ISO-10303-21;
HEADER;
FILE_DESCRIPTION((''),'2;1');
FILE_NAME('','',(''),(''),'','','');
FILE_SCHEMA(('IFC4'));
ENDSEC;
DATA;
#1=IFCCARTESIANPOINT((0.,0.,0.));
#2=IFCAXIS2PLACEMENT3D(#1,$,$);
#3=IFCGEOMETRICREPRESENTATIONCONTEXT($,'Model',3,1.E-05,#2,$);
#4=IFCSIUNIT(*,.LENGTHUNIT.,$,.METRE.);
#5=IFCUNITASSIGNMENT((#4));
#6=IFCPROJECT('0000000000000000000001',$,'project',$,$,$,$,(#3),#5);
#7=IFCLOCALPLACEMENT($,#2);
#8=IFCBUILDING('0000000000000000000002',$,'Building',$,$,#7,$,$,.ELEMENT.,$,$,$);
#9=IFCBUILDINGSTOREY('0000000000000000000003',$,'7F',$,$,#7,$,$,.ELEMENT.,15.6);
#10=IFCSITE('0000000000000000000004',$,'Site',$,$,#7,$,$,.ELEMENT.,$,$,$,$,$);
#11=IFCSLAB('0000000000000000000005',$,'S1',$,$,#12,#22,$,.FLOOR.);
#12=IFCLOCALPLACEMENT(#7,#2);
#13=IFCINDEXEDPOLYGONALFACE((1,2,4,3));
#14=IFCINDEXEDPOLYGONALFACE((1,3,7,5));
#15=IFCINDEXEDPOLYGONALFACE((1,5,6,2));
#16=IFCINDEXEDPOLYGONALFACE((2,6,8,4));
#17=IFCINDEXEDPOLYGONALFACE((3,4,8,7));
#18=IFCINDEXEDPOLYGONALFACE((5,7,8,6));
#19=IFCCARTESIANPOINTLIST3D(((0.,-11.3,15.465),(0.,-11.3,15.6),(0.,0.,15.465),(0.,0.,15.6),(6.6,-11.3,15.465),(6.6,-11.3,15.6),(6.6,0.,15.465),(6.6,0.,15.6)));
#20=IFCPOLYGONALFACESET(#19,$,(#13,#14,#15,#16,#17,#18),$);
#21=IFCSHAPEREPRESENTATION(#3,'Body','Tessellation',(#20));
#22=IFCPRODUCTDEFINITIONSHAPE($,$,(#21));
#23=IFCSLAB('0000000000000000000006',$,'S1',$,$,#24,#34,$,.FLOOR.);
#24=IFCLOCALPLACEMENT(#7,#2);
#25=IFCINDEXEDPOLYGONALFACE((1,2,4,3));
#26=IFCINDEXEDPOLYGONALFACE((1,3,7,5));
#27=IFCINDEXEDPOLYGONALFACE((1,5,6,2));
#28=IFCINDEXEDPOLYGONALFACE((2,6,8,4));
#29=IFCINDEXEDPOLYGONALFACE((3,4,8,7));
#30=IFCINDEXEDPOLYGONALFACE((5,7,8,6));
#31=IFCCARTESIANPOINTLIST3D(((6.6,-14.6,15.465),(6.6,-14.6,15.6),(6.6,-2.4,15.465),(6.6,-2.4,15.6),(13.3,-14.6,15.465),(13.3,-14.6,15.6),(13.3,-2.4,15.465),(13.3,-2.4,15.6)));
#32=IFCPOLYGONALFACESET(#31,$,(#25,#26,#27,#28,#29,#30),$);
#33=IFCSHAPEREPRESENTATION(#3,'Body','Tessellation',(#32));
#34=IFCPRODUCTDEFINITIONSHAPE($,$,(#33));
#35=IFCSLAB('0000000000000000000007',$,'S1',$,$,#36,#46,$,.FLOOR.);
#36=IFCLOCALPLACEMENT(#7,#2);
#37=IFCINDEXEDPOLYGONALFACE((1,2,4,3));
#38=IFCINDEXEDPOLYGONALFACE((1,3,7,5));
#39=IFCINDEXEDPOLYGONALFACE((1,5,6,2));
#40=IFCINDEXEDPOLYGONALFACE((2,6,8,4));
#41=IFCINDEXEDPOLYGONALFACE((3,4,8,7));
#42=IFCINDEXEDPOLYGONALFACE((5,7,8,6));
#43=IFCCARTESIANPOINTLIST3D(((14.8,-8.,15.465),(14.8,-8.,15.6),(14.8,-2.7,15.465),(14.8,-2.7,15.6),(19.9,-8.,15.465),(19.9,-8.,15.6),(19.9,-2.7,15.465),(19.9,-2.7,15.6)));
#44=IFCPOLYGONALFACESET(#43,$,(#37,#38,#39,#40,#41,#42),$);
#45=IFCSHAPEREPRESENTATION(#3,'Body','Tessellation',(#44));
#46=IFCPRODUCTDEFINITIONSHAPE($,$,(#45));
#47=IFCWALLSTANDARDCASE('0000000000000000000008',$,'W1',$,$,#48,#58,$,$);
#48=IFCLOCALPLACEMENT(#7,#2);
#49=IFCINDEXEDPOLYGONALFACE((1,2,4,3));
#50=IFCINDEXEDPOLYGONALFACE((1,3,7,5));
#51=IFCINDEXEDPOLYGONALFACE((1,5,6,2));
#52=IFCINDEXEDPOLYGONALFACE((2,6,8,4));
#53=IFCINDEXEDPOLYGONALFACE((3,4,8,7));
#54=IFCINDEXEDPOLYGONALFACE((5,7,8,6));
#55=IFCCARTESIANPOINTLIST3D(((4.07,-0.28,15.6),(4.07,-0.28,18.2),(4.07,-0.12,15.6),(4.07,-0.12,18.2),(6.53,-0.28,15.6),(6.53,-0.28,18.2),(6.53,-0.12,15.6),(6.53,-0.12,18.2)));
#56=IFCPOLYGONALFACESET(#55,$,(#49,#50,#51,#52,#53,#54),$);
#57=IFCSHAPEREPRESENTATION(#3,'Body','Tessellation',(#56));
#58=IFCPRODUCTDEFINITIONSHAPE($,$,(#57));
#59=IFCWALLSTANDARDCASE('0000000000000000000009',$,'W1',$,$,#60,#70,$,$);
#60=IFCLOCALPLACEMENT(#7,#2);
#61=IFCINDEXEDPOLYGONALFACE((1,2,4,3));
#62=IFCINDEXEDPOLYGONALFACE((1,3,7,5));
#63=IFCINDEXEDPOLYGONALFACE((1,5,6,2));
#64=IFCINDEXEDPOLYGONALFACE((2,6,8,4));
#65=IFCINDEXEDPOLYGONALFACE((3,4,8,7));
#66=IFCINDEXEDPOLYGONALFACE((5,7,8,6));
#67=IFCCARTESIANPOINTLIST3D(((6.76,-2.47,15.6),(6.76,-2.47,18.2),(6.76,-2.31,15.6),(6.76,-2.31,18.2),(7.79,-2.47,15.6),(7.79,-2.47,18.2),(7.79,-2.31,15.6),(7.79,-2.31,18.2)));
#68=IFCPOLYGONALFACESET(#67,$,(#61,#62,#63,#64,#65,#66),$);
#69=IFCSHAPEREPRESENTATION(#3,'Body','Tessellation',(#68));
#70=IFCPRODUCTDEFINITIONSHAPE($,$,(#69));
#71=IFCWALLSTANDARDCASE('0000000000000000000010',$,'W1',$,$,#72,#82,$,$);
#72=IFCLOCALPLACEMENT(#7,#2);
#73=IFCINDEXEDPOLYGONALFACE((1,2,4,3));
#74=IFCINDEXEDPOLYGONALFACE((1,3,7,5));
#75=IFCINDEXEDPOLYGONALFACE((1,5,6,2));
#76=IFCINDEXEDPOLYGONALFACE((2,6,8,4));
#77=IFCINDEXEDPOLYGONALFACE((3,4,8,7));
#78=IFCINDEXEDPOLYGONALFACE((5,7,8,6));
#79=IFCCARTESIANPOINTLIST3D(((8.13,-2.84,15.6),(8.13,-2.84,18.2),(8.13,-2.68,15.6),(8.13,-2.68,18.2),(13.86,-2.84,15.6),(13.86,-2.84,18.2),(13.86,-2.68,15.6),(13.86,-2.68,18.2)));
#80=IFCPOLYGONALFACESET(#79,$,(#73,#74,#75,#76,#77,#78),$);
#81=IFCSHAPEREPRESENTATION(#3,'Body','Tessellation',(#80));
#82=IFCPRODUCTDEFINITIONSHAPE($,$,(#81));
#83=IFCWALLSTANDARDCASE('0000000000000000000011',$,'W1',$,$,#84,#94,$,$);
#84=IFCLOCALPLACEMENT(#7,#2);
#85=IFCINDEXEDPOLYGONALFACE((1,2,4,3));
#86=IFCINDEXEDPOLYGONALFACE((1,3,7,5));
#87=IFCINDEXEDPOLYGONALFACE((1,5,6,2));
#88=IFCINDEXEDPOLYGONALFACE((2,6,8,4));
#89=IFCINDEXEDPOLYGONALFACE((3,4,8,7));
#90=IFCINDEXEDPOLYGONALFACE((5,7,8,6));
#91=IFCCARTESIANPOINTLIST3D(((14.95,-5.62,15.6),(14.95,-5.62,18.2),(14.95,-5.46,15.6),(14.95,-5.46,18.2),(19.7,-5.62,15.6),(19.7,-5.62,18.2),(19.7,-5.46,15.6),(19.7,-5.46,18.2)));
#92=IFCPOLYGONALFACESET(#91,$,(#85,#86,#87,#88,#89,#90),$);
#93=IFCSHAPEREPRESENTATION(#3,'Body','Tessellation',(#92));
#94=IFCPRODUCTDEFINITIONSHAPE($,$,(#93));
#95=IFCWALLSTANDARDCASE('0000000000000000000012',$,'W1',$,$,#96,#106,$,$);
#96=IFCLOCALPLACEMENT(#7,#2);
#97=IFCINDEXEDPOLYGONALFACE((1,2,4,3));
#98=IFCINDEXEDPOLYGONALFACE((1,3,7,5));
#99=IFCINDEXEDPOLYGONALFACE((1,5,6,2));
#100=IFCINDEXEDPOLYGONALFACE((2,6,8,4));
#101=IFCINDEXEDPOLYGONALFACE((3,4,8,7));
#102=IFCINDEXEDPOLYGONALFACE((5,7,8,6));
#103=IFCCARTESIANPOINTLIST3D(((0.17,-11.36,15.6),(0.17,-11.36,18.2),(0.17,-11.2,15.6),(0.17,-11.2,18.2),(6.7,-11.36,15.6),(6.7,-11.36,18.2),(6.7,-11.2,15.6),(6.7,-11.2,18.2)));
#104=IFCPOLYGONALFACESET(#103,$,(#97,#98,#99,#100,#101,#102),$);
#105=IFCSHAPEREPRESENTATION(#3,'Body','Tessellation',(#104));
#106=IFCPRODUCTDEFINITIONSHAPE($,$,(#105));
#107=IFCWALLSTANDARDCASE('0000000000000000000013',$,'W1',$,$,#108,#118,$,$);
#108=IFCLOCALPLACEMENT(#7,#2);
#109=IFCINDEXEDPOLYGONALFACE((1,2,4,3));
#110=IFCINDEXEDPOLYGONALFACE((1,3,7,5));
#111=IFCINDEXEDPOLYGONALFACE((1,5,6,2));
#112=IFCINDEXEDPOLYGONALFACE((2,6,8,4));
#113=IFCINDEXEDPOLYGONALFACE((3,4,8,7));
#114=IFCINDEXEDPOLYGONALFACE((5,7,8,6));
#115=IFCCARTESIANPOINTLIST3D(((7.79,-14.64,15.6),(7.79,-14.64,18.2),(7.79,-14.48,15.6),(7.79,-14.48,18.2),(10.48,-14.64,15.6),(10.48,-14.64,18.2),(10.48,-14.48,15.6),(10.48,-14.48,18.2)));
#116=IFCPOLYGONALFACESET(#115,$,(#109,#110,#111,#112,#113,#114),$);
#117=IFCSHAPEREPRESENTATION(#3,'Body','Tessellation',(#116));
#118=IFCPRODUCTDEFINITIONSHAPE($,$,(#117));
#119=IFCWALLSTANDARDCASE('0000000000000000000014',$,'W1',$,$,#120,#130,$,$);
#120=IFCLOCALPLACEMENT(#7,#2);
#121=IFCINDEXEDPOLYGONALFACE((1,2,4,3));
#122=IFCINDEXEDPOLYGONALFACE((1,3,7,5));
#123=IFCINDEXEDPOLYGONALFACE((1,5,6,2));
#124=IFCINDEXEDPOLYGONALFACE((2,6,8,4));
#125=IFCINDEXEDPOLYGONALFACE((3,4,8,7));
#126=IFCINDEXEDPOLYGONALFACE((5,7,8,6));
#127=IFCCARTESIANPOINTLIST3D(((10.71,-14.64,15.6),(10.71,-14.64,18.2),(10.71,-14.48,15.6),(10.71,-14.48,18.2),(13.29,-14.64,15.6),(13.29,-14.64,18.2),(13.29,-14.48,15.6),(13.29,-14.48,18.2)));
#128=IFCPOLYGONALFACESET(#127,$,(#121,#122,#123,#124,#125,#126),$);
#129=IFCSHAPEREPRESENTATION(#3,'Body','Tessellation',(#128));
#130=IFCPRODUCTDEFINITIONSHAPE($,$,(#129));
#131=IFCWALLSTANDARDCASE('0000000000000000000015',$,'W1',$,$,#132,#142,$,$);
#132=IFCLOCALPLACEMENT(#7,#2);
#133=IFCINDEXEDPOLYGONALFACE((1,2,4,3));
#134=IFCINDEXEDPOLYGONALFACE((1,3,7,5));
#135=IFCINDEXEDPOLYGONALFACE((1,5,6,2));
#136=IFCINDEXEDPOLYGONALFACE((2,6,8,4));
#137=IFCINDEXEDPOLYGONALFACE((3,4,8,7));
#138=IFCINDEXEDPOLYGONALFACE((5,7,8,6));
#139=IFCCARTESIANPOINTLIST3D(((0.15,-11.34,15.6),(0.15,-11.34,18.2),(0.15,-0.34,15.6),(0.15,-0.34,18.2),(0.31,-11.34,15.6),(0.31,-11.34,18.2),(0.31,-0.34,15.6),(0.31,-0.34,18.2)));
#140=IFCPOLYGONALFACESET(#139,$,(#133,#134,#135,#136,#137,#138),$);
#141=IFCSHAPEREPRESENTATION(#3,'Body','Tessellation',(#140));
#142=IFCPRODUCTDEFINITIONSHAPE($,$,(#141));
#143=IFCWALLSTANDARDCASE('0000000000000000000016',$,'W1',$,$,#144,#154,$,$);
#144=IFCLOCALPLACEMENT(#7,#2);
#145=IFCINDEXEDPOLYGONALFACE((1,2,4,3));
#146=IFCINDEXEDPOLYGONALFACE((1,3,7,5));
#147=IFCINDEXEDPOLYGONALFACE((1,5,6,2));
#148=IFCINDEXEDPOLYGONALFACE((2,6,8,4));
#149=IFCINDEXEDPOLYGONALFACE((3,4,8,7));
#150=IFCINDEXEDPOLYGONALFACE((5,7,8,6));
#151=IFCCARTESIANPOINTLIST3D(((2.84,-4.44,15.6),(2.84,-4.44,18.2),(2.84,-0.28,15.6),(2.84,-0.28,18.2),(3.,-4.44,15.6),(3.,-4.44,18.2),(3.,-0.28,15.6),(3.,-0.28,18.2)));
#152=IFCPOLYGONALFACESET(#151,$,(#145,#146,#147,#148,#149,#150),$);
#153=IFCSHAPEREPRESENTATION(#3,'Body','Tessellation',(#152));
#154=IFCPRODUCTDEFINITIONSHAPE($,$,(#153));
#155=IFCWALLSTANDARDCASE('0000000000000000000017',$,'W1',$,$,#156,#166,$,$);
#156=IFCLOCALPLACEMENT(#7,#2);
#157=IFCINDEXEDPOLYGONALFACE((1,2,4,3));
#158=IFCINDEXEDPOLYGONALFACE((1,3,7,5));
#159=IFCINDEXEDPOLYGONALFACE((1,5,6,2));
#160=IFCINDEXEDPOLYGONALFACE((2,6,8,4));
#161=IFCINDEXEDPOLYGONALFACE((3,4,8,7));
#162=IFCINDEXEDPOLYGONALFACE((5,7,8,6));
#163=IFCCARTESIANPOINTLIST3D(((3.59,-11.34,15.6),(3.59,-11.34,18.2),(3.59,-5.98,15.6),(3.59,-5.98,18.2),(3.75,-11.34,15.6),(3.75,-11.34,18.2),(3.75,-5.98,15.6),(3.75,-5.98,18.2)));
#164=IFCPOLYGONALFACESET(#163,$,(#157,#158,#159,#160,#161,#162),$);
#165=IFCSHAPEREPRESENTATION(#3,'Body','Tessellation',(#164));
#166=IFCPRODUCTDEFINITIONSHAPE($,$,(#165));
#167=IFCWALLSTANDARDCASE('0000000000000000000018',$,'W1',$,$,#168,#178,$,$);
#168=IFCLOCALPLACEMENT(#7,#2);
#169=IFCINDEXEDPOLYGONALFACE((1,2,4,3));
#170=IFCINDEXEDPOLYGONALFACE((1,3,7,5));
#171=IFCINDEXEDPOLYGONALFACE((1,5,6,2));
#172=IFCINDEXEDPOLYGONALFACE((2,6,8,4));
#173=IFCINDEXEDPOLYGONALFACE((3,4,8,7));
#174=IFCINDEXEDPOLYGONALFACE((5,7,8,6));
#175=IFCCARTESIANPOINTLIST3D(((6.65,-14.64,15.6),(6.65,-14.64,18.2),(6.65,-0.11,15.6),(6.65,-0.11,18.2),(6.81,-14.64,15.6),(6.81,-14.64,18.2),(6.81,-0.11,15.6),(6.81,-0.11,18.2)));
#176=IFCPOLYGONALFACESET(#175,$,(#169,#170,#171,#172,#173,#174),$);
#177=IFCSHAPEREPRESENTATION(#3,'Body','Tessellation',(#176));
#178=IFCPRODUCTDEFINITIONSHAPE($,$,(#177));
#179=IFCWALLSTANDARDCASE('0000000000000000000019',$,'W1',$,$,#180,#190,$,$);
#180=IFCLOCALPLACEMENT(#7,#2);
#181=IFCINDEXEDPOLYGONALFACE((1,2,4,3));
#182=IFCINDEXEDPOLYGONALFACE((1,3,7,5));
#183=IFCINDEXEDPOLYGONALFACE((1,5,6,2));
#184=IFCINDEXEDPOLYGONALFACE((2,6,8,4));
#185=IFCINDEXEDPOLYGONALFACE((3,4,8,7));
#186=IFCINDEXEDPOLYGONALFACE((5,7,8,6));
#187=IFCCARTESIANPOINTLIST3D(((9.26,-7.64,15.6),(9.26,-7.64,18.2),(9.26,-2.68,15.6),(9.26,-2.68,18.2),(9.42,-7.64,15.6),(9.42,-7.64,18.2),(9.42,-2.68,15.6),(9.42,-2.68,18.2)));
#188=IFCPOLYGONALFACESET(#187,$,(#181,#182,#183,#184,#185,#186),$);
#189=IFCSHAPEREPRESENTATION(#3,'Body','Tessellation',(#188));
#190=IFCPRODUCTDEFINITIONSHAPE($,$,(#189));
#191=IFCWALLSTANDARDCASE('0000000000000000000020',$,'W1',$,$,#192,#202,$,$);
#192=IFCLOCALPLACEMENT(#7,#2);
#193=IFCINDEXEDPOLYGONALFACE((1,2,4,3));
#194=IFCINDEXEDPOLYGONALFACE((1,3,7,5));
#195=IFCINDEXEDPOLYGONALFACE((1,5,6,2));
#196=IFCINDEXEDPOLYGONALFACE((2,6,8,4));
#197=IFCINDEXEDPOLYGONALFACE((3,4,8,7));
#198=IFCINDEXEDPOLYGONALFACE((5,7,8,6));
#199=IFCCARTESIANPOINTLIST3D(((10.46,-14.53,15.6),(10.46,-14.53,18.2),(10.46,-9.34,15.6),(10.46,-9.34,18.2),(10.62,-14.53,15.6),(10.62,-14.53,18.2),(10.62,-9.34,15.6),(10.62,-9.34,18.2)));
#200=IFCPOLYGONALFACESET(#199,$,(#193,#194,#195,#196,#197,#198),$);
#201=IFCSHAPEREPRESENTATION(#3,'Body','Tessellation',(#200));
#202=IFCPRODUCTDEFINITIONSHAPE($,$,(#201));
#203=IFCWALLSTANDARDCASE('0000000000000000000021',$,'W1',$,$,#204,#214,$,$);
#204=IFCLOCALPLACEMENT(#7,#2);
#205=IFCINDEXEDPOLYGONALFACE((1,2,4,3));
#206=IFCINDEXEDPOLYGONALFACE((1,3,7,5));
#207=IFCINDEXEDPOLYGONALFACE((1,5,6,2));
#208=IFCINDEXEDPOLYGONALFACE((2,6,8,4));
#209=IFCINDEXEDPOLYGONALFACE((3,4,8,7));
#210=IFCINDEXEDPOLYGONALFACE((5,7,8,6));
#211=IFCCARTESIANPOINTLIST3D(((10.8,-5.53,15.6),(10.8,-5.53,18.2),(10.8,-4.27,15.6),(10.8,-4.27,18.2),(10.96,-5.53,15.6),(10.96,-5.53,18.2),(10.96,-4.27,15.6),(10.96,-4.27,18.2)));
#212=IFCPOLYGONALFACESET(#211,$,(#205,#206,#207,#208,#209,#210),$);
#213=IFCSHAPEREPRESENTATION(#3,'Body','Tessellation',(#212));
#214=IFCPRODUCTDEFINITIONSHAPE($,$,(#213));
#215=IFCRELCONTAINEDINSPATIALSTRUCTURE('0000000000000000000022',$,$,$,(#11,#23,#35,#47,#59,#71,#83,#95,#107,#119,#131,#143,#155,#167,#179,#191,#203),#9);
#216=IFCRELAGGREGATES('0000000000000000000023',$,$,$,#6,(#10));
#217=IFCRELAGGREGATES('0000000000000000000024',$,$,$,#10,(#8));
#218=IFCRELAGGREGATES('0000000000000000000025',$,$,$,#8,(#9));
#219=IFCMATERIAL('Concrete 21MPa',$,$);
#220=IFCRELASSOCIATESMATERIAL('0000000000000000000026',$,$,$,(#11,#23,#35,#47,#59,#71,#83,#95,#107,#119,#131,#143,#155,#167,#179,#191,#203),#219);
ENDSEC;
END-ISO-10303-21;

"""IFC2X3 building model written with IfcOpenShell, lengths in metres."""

from ifc_helpers import new_model, si_unit, frame, origin, origin_2d, place, context, project, spatial, rectangle, extrude, material, element, save


model = new_model("IFC2X3")

# Units and contexts
model_context = context("Model", 3, precision=1e-05, world=origin())
ifc_project = project(units=[si_unit("LENGTHUNIT", "METRE")], contexts=[model_context])

# Site, building, storey
placement = place(None, origin())
site = spatial("IfcSite", under=ifc_project, at=placement, Name="Site", CompositionType="ELEMENT")
building = spatial("IfcBuilding", under=site, at=placement, Name="Building", CompositionType="ELEMENT")
storey = spatial("IfcBuildingStorey", under=building, at=placement, Name="7F", CompositionType="ELEMENT", Elevation=15.6)

# Slabs
ifc_material_1 = material(Name="Concrete 21MPa")
slab_1_placement = place(None, frame((3.3, -5.65, 15.465)))
element("IfcSlab", 1, at=slab_1_placement, inside=storey, material=ifc_material_1, Name="S1", PredefinedType="FLOOR", context=model_context, shape_type="SweptSolid", body=[
    extrude(rectangle(XDim=6.6, YDim=11.3, at=origin_2d()), origin(), (0.0, 0.0, 1.0), 0.135),
])
slab_2_placement = place(None, frame((9.95, -8.5, 15.465)))
element("IfcSlab", 2, at=slab_2_placement, inside=storey, material=ifc_material_1, Name="S1", PredefinedType="FLOOR", context=model_context, shape_type="SweptSolid", body=[
    extrude(rectangle(XDim=6.7, YDim=12.2, at=origin_2d()), origin(), (0.0, 0.0, 1.0), 0.135),
])
slab_3_placement = place(None, frame((17.35, -5.35, 15.465)))
element("IfcSlab", 3, at=slab_3_placement, inside=storey, material=ifc_material_1, Name="S1", PredefinedType="FLOOR", context=model_context, shape_type="SweptSolid", body=[
    extrude(rectangle(XDim=5.1, YDim=5.3, at=origin_2d()), origin(), (0.0, 0.0, 1.0), 0.135),
])

# Walls
wall_1_placement = place(None, frame((5.3, -0.2, 15.6)))
element("IfcWallStandardCase", 4, at=wall_1_placement, inside=storey, material=ifc_material_1, Name="W1", context=model_context, shape_type="SweptSolid", body=[
    extrude(rectangle(XDim=2.46, YDim=0.16, at=origin_2d()), origin(), (0.0, 0.0, 1.0), 2.6),
])
wall_2_placement = place(None, frame((7.275, -2.39, 15.6)))
element("IfcWallStandardCase", 5, at=wall_2_placement, inside=storey, material=ifc_material_1, Name="W1", context=model_context, shape_type="SweptSolid", body=[
    extrude(rectangle(XDim=1.03, YDim=0.16, at=origin_2d()), origin(), (0.0, 0.0, 1.0), 2.6),
])
wall_3_placement = place(None, frame((10.995, -2.76, 15.6)))
element("IfcWallStandardCase", 6, at=wall_3_placement, inside=storey, material=ifc_material_1, Name="W1", context=model_context, shape_type="SweptSolid", body=[
    extrude(rectangle(XDim=5.73, YDim=0.16, at=origin_2d()), origin(), (0.0, 0.0, 1.0), 2.6),
])
wall_4_placement = place(None, frame((17.325, -5.54, 15.6)))
element("IfcWallStandardCase", 7, at=wall_4_placement, inside=storey, material=ifc_material_1, Name="W1", context=model_context, shape_type="SweptSolid", body=[
    extrude(rectangle(XDim=4.75, YDim=0.16, at=origin_2d()), origin(), (0.0, 0.0, 1.0), 2.6),
])
wall_5_placement = place(None, frame((3.435, -11.28, 15.6)))
element("IfcWallStandardCase", 8, at=wall_5_placement, inside=storey, material=ifc_material_1, Name="W1", context=model_context, shape_type="SweptSolid", body=[
    extrude(rectangle(XDim=6.53, YDim=0.16, at=origin_2d()), origin(), (0.0, 0.0, 1.0), 2.6),
])
wall_6_placement = place(None, frame((9.135, -14.56, 15.6)))
element("IfcWallStandardCase", 9, at=wall_6_placement, inside=storey, material=ifc_material_1, Name="W1", context=model_context, shape_type="SweptSolid", body=[
    extrude(rectangle(XDim=2.69, YDim=0.16, at=origin_2d()), origin(), (0.0, 0.0, 1.0), 2.6),
])
wall_7_placement = place(None, frame((12.0, -14.56, 15.6)))
element("IfcWallStandardCase", 10, at=wall_7_placement, inside=storey, material=ifc_material_1, Name="W1", context=model_context, shape_type="SweptSolid", body=[
    extrude(rectangle(XDim=2.58, YDim=0.16, at=origin_2d()), origin(), (0.0, 0.0, 1.0), 2.6),
])
wall_8_placement = place(None, frame((0.23, -5.84, 15.6)))
element("IfcWallStandardCase", 11, at=wall_8_placement, inside=storey, material=ifc_material_1, Name="W1", context=model_context, shape_type="SweptSolid", body=[
    extrude(rectangle(XDim=0.16, YDim=11.0, at=origin_2d()), origin(), (0.0, 0.0, 1.0), 2.6),
])
wall_9_placement = place(None, frame((2.92, -2.36, 15.6)))
element("IfcWallStandardCase", 12, at=wall_9_placement, inside=storey, material=ifc_material_1, Name="W1", context=model_context, shape_type="SweptSolid", body=[
    extrude(rectangle(XDim=0.16, YDim=4.16, at=origin_2d()), origin(), (0.0, 0.0, 1.0), 2.6),
])
wall_10_placement = place(None, frame((3.67, -8.66, 15.6)))
element("IfcWallStandardCase", 13, at=wall_10_placement, inside=storey, material=ifc_material_1, Name="W1", context=model_context, shape_type="SweptSolid", body=[
    extrude(rectangle(XDim=0.16, YDim=5.36, at=origin_2d()), origin(), (0.0, 0.0, 1.0), 2.6),
])
wall_11_placement = place(None, frame((6.73, -7.375, 15.6)))
element("IfcWallStandardCase", 14, at=wall_11_placement, inside=storey, material=ifc_material_1, Name="W1", context=model_context, shape_type="SweptSolid", body=[
    extrude(rectangle(XDim=0.16, YDim=14.53, at=origin_2d()), origin(), (0.0, 0.0, 1.0), 2.6),
])
wall_12_placement = place(None, frame((9.34, -5.16, 15.6)))
element("IfcWallStandardCase", 15, at=wall_12_placement, inside=storey, material=ifc_material_1, Name="W1", context=model_context, shape_type="SweptSolid", body=[
    extrude(rectangle(XDim=0.16, YDim=4.96, at=origin_2d()), origin(), (0.0, 0.0, 1.0), 2.6),
])
wall_13_placement = place(None, frame((10.54, -11.935, 15.6)))
element("IfcWallStandardCase", 16, at=wall_13_placement, inside=storey, material=ifc_material_1, Name="W1", context=model_context, shape_type="SweptSolid", body=[
    extrude(rectangle(XDim=0.16, YDim=5.19, at=origin_2d()), origin(), (0.0, 0.0, 1.0), 2.6),
])
wall_14_placement = place(None, frame((10.88, -4.9, 15.6)))
element("IfcWallStandardCase", 17, at=wall_14_placement, inside=storey, material=ifc_material_1, Name="W1", context=model_context, shape_type="SweptSolid", body=[
    extrude(rectangle(XDim=0.16, YDim=1.26, at=origin_2d()), origin(), (0.0, 0.0, 1.0), 2.6),
])

save(model, "model.ifc")
